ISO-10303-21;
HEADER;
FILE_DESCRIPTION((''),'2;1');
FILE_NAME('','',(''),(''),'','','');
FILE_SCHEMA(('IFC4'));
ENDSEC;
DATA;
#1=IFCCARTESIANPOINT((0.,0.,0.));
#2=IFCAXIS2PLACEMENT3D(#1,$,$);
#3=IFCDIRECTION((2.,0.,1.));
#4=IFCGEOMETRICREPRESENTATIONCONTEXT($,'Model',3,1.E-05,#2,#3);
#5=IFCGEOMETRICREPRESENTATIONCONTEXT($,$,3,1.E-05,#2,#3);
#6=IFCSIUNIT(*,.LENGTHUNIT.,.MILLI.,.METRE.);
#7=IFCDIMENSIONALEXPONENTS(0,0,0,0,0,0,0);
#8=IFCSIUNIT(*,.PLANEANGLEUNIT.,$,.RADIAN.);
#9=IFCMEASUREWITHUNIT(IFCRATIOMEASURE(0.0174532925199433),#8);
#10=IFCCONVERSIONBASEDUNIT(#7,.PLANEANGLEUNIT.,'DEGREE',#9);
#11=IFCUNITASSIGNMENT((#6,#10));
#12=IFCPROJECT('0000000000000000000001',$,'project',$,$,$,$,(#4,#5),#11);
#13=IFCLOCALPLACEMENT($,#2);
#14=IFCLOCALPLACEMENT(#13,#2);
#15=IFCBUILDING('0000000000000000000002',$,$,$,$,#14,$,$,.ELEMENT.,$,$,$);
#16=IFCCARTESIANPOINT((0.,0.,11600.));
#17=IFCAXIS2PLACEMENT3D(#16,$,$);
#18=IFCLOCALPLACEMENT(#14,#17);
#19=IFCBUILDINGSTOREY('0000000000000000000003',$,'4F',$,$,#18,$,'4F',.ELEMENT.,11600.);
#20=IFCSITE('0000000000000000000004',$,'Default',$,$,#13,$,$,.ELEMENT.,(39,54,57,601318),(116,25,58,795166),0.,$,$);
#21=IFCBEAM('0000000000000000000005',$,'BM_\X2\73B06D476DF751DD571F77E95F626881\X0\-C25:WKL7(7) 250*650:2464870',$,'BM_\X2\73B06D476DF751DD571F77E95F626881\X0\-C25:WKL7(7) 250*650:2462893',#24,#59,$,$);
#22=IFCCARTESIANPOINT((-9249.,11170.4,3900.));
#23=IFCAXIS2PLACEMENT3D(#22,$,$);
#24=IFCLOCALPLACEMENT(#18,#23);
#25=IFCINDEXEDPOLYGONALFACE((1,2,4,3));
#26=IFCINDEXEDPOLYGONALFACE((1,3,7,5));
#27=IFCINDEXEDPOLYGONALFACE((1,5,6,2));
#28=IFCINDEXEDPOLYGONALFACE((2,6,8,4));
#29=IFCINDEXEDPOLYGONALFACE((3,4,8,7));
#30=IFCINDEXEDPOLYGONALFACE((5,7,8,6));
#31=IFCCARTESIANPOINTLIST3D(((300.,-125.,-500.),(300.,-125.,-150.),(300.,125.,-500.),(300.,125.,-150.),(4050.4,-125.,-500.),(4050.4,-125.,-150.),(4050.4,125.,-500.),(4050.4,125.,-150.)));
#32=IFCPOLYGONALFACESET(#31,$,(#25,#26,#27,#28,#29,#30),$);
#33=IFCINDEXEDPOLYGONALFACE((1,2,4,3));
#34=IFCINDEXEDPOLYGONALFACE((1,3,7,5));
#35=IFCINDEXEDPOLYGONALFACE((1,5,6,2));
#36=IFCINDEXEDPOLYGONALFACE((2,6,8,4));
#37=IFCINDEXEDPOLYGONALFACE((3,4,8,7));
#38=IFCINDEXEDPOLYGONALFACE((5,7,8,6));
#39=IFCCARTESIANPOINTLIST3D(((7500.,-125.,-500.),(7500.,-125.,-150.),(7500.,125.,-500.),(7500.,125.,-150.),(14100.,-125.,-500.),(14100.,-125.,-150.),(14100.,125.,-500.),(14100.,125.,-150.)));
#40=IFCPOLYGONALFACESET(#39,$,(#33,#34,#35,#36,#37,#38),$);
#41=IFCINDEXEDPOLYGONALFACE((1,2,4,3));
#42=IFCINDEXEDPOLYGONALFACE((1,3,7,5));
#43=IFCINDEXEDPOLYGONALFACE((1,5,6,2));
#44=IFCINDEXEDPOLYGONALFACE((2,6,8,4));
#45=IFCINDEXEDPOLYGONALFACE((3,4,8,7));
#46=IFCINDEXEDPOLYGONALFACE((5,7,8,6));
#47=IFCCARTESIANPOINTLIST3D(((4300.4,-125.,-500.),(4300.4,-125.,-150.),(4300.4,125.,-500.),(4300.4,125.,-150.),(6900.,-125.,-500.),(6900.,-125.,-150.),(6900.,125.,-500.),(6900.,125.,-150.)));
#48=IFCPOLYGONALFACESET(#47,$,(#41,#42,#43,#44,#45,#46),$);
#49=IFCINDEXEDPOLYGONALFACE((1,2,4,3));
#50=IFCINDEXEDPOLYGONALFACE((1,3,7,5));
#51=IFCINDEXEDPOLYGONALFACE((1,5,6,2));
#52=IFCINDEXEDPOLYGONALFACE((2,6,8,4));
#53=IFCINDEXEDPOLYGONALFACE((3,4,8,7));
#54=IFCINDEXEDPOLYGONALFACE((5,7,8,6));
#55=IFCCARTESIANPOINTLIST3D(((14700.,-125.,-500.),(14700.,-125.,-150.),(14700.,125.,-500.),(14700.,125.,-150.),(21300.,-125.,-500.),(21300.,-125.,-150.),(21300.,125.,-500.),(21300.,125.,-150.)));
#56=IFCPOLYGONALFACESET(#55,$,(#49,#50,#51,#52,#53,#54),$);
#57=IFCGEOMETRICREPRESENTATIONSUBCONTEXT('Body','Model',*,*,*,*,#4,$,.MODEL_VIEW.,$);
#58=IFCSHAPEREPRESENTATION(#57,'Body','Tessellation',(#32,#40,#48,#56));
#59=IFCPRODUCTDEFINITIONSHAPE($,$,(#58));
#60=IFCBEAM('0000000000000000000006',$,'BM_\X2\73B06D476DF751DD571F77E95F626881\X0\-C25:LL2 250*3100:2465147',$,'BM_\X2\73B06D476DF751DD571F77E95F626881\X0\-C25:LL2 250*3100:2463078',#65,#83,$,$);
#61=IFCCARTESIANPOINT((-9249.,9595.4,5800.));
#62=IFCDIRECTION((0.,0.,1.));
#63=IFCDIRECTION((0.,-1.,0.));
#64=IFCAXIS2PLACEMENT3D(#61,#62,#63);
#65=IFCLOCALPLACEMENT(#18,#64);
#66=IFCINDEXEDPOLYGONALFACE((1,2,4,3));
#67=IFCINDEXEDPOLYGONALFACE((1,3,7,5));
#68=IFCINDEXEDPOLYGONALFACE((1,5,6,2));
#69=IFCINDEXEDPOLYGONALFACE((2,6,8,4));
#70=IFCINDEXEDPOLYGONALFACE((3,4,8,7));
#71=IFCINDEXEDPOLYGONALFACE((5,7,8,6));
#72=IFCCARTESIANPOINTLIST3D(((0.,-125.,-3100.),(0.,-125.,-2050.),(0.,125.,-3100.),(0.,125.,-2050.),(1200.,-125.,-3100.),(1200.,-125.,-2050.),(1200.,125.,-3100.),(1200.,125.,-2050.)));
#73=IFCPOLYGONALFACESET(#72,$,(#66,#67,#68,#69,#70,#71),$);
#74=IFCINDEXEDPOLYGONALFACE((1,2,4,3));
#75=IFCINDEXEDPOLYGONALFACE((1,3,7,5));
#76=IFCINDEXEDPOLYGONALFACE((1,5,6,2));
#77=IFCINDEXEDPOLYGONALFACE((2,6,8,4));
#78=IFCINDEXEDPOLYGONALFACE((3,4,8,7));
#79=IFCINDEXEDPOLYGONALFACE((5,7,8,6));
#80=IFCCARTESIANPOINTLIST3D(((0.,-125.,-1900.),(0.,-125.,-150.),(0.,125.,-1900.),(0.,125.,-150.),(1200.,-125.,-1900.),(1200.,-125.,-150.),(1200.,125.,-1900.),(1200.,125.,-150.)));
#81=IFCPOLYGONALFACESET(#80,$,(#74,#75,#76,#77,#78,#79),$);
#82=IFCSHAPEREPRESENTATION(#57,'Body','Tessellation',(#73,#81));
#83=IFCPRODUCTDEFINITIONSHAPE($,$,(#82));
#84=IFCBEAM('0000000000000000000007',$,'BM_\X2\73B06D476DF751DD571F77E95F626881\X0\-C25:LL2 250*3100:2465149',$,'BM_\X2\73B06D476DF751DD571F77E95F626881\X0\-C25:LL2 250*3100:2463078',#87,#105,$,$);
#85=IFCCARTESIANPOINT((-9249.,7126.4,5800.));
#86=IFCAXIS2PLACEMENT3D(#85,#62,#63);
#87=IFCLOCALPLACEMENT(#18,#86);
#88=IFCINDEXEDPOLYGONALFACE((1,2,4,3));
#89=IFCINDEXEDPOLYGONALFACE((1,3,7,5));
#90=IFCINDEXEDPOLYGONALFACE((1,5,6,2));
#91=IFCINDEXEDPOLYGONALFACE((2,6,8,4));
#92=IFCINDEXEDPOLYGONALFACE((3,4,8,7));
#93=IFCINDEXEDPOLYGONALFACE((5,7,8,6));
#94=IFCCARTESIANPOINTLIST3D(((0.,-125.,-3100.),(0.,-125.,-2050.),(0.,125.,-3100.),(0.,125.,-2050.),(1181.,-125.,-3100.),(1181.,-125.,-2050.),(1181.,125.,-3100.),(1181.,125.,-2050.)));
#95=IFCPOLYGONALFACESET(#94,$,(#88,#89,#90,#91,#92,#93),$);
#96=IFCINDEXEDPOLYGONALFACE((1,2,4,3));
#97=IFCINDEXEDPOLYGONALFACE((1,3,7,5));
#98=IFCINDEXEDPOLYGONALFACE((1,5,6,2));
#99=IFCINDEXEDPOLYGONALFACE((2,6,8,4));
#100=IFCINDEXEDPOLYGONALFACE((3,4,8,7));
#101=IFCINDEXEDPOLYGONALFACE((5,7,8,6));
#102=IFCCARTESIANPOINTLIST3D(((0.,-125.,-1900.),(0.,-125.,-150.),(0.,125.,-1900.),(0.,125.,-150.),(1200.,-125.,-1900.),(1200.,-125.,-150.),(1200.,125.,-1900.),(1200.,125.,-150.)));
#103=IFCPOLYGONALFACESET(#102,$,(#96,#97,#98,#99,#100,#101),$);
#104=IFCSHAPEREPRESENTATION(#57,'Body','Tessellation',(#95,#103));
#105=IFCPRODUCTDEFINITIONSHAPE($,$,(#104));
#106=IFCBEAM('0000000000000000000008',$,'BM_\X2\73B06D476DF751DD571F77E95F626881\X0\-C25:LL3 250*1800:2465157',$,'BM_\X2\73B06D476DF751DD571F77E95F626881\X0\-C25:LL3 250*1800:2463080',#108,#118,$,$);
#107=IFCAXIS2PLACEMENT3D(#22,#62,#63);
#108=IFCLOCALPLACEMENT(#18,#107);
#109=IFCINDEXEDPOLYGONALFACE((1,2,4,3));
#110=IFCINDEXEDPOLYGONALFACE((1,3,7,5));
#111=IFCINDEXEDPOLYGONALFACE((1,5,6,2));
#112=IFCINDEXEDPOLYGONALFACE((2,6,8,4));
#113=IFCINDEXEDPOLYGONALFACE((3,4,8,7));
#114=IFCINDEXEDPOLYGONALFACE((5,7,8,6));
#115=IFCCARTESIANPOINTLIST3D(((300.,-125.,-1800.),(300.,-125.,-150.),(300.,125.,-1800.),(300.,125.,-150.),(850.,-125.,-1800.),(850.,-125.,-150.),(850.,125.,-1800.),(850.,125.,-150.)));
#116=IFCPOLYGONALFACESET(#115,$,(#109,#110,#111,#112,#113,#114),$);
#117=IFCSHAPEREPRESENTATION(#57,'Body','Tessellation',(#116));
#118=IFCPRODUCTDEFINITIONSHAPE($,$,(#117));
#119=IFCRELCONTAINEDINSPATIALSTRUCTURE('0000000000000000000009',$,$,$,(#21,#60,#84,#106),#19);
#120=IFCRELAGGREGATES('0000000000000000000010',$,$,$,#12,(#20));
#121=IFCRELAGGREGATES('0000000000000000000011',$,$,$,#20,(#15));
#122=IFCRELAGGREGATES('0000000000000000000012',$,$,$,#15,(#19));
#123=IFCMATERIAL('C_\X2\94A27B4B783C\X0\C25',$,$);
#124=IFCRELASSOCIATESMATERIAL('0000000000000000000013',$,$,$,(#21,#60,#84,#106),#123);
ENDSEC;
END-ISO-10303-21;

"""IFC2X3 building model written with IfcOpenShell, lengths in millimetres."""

from ifc_helpers import new_model, entity, si_unit, converted_unit, direction, frame, frame_2d, origin, origin_2d_with_axis, place, context, subcontext, project, spatial, rectangle, extrude, material, element, save


model = new_model("IFC2X3")

# Units and contexts
model_context = context("Model", 3, precision=1e-05, world=origin(), true_north=direction((2.0, 0.0, 1.0)))
context_of_model = context(None, 3, precision=1e-05, world=origin(), true_north=direction((2.0, 0.0, 1.0)))
body_context = subcontext(model_context, "Body", "Model", "MODEL_VIEW")
ifc_project = project(units=[si_unit("LENGTHUNIT", "METRE", prefix="MILLI"), converted_unit("PLANEANGLEUNIT", "DEGREE", entity("IfcRatioMeasure", 0.0174532925199433), si_unit("PLANEANGLEUNIT", "RADIAN"), dimensions=[0, 0, 0, 0, 0, 0, 0])], contexts=[model_context, context_of_model])

# Site, building, storey
site_placement = place(None, origin())
site = spatial("IfcSite", under=ifc_project, at=site_placement, Name="Default", CompositionType="ELEMENT", RefLatitude=(39, 54, 57, 601318), RefLongitude=(116, 25, 58, 795166), RefElevation=0.0)
building_placement = place(site_placement, origin())
building = spatial("IfcBuilding", under=site, at=building_placement, CompositionType="ELEMENT")
storey_placement = place(building_placement, frame((0.0, 0.0, 11600.0)))
storey = spatial("IfcBuildingStorey", under=building, at=storey_placement, Name="4F", LongName="4F", CompositionType="ELEMENT", Elevation=11600.0)

# Shared definitions
ifc_material = material(Name="C_钢筋砼C25")

# Beams
beam_1_placement = place(storey_placement, frame((-9249.0, 11170.4, 3900.0)))
element("IfcBeam", 1, at=beam_1_placement, inside=storey, material=ifc_material, Name="BM_现浇混凝土矩形梁-C25:WKL7(7) 250*650:2464870", ObjectType="BM_现浇混凝土矩形梁-C25:WKL7(7) 250*650:2462893", context=body_context, shape_type="SweptSolid", body=[
    extrude(rectangle(XDim=350.0, YDim=250.0, at=origin_2d_with_axis()), frame((300.0, 0.0, -325.0), z_axis=(1.0, 0.0, 0.0), x_axis=(0.0, 0.0, 1.0)), (0.0, 0.0, 1.0), 3750.4),
    extrude(rectangle(XDim=350.0, YDim=250.0, at=origin_2d_with_axis()), frame((7500.0, 0.0, -325.0), z_axis=(1.0, 0.0, 0.0), x_axis=(0.0, 0.0, 1.0)), (0.0, 0.0, 1.0), 6600.0),
    extrude(rectangle(XDim=350.0, YDim=250.0, at=origin_2d_with_axis()), frame((4300.4, 0.0, -325.0), z_axis=(1.0, 0.0, 0.0), x_axis=(0.0, 0.0, 1.0)), (0.0, 0.0, 1.0), 2599.6),
    extrude(rectangle(XDim=350.0, YDim=250.0, at=origin_2d_with_axis()), frame((14700.0, 0.0, -325.0), z_axis=(1.0, 0.0, 0.0), x_axis=(0.0, 0.0, 1.0)), (0.0, 0.0, 1.0), 6600.0),
])
beam_2_placement = place(storey_placement, frame((-9249.0, 9595.4, 5800.0), z_axis=(0.0, 0.0, 1.0), x_axis=(0.0, -1.0, 0.0)))
element("IfcBeam", 2, at=beam_2_placement, inside=storey, material=ifc_material, Name="BM_现浇混凝土矩形梁-C25:LL2 250*3100:2465147", ObjectType="BM_现浇混凝土矩形梁-C25:LL2 250*3100:2463078", context=body_context, shape_type="SweptSolid", body=[
    extrude(rectangle(XDim=1050.0, YDim=250.0, at=frame_2d((0.0, 0.0), x_axis=(1.0, 0.0))), frame((0.0, 0.0, -2575.0), z_axis=(1.0, 0.0, 0.0), x_axis=(0.0, 0.0, 1.0)), (0.0, 0.0, 1.0), 1200.0),
    extrude(rectangle(XDim=1750.0, YDim=250.0, at=frame_2d((0.0, 0.0), x_axis=(1.0, 0.0))), frame((0.0, 0.0, -1025.0), z_axis=(1.0, 0.0, 0.0), x_axis=(0.0, 0.0, 1.0)), (0.0, 0.0, 1.0), 1200.0),
])
beam_3_placement = place(storey_placement, frame((-9249.0, 7126.4, 5800.0), z_axis=(0.0, 0.0, 1.0), x_axis=(0.0, -1.0, 0.0)))
element("IfcBeam", 3, at=beam_3_placement, inside=storey, material=ifc_material, Name="BM_现浇混凝土矩形梁-C25:LL2 250*3100:2465149", ObjectType="BM_现浇混凝土矩形梁-C25:LL2 250*3100:2463078", context=body_context, shape_type="SweptSolid", body=[
    extrude(rectangle(XDim=1050.0, YDim=250.0, at=frame_2d((0.0, 0.0), x_axis=(1.0, 0.0))), frame((0.0, 0.0, -2575.0), z_axis=(1.0, 0.0, 0.0), x_axis=(0.0, 0.0, 1.0)), (0.0, 0.0, 1.0), 1181.0),
    extrude(rectangle(XDim=1750.0, YDim=250.0, at=frame_2d((0.0, 0.0), x_axis=(1.0, 0.0))), frame((0.0, 0.0, -1025.0), z_axis=(1.0, 0.0, 0.0), x_axis=(0.0, 0.0, 1.0)), (0.0, 0.0, 1.0), 1200.0),
])
beam_4_placement = place(storey_placement, frame((-9249.0, 11170.4, 3900.0), z_axis=(0.0, 0.0, 1.0), x_axis=(0.0, -1.0, 0.0)))
element("IfcBeam", 4, at=beam_4_placement, inside=storey, material=ifc_material, Name="BM_现浇混凝土矩形梁-C25:LL3 250*1800:2465157", ObjectType="BM_现浇混凝土矩形梁-C25:LL3 250*1800:2463080", context=body_context, shape_type="SweptSolid", body=[
    extrude(rectangle(XDim=1650.0, YDim=250.0, at=frame_2d((0.0, 0.0), x_axis=(1.0, 0.0))), frame((300.0, 0.0, -975.0), z_axis=(1.0, 0.0, 0.0), x_axis=(0.0, 0.0, -1.0)), (0.0, 0.0, 1.0), 550.0),
])

save(model, "model.ifc")
